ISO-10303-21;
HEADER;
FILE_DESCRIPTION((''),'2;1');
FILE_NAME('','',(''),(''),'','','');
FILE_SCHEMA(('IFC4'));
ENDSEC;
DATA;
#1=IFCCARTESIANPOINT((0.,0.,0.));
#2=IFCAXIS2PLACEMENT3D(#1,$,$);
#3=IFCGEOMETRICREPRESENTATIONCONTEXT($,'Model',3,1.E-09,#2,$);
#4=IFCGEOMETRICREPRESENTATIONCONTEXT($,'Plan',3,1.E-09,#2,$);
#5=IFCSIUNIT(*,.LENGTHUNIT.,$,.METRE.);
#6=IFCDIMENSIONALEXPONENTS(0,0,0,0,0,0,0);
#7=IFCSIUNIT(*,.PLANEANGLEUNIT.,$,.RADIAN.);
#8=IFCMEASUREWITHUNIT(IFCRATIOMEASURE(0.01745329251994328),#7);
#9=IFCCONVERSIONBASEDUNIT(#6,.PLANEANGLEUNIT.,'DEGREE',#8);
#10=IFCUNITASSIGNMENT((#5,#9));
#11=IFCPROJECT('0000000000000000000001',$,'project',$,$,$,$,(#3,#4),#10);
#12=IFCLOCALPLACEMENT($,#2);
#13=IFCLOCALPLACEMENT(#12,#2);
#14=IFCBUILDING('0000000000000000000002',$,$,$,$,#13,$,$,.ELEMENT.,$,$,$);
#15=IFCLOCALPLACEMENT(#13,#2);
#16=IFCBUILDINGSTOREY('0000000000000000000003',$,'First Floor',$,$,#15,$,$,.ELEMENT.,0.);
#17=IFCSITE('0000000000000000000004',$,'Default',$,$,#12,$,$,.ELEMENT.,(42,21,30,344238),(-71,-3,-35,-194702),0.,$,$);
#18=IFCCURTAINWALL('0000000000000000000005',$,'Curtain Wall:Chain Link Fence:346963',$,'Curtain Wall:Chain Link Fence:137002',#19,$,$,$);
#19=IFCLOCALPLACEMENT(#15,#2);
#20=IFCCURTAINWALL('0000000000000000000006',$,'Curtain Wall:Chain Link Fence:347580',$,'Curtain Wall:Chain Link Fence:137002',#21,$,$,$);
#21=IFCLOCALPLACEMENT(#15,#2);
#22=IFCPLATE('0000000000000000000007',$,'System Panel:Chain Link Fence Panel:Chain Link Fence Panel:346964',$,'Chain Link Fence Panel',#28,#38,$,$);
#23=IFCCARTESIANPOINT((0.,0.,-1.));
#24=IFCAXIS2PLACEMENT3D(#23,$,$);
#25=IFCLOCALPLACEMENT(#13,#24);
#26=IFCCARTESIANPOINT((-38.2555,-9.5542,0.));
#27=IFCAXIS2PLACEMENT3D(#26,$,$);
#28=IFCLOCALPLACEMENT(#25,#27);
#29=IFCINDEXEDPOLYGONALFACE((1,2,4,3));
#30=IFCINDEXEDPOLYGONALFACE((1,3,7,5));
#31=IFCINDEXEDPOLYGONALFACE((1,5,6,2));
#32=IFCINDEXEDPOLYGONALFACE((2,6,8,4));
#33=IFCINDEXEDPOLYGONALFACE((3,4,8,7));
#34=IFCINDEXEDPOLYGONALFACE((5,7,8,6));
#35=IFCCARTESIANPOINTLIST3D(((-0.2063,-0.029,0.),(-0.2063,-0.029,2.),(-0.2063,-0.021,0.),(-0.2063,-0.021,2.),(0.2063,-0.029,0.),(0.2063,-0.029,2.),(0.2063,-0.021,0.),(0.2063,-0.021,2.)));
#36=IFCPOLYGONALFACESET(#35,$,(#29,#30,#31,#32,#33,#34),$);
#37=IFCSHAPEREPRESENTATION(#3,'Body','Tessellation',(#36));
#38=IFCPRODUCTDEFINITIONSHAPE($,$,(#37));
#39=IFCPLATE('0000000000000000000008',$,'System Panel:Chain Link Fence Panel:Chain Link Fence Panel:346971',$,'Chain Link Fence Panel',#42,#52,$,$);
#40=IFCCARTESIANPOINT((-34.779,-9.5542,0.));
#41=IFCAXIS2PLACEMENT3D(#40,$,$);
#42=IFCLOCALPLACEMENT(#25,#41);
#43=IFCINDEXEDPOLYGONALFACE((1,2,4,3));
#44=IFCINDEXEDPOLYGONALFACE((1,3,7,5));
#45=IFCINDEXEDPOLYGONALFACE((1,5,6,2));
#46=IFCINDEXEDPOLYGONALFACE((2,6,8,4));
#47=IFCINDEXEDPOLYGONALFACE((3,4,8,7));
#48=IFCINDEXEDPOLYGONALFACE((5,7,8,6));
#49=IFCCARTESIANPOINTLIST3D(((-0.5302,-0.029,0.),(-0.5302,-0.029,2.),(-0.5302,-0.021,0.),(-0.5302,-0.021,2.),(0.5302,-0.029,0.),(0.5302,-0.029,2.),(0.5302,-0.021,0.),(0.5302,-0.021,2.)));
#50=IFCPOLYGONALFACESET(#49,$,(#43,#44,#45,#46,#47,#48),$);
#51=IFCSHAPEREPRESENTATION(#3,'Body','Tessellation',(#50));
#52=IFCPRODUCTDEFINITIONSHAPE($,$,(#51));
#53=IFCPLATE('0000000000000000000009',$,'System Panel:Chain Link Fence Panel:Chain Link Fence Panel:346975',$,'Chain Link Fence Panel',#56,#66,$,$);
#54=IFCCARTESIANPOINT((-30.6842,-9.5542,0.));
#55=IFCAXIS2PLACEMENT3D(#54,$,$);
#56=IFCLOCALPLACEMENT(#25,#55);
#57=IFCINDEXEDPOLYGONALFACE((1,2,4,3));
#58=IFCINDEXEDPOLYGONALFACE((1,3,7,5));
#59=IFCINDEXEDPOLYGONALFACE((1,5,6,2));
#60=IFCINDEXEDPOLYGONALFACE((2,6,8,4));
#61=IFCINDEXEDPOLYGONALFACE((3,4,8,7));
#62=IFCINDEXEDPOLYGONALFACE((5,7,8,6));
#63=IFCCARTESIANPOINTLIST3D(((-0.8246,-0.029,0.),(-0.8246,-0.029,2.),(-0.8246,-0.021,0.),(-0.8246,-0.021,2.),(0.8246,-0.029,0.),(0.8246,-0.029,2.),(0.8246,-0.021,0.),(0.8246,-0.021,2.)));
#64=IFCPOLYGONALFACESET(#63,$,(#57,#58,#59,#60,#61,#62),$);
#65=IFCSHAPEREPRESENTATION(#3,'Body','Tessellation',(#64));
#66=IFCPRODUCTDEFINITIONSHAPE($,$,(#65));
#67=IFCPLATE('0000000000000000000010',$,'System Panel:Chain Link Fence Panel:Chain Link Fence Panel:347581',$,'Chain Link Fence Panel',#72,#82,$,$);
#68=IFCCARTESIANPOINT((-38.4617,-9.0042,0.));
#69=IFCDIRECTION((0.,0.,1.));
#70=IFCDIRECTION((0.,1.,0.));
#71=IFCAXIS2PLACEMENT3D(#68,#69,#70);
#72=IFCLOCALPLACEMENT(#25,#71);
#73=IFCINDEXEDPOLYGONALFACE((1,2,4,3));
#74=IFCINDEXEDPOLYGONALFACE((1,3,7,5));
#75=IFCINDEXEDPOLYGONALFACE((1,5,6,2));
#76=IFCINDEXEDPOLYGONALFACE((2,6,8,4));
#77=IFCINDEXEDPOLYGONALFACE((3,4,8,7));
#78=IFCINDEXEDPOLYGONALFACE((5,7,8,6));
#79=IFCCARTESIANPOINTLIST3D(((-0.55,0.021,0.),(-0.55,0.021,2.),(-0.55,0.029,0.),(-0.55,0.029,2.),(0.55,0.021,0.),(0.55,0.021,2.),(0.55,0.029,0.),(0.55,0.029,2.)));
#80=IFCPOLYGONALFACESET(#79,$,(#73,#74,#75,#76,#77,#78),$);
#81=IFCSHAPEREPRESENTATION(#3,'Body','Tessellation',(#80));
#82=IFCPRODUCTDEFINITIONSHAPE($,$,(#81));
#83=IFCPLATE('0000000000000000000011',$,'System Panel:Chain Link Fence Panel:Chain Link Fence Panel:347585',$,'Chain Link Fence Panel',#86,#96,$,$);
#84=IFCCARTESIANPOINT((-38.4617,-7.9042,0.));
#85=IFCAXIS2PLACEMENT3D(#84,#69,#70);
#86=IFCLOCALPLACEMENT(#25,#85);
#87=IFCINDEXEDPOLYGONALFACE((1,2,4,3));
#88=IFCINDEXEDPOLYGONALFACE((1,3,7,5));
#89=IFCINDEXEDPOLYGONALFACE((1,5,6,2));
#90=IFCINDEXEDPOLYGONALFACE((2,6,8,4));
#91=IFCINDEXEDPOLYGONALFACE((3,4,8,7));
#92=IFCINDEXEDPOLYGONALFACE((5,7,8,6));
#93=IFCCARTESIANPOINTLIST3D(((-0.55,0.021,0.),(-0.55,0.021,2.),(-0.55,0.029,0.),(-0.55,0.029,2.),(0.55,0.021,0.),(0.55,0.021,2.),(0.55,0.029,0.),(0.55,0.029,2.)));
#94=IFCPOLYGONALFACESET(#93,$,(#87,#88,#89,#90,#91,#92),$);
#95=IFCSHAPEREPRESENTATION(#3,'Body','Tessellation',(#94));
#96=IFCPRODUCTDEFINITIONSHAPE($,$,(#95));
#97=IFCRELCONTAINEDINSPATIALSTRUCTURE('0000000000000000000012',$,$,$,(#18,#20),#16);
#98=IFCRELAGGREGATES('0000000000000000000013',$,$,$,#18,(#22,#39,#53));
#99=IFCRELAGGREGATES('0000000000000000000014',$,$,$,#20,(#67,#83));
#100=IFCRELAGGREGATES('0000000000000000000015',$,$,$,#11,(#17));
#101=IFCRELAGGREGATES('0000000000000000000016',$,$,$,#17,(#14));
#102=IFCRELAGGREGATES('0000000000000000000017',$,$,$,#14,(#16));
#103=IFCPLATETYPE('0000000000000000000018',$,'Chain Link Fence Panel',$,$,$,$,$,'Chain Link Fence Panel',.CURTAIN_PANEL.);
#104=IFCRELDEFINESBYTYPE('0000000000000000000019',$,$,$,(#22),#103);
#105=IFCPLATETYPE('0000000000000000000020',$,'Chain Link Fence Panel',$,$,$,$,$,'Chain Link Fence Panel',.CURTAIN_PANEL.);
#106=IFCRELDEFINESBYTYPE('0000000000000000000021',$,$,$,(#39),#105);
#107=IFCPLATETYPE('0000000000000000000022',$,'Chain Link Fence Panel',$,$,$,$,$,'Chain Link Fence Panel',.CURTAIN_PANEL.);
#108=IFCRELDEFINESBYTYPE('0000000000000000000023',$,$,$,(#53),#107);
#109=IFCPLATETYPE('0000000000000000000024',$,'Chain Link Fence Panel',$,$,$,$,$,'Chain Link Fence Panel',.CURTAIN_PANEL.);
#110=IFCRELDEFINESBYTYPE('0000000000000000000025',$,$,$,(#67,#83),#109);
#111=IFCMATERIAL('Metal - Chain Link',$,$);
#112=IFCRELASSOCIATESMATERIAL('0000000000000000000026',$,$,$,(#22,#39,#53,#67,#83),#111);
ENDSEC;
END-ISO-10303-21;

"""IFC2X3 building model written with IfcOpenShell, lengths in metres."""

from ifc_helpers import new_model, entity, si_unit, converted_unit, frame, origin, origin_2d_with_axis, place, context, project, spatial, rectangle, extrude, source, transform, mapped, material, type_object, type_shapes, element, aggregate, save


model = new_model("IFC2X3")

# Units and contexts
model_context = context("Model", 3, precision=1e-09, world=origin())
plan_context = context("Plan", 3, precision=1e-09, world=origin())
ifc_project = project(units=[si_unit("LENGTHUNIT", "METRE"), converted_unit("PLANEANGLEUNIT", "DEGREE", entity("IfcRatioMeasure", 0.01745329251994328), si_unit("PLANEANGLEUNIT", "RADIAN"), dimensions=[0, 0, 0, 0, 0, 0, 0])], contexts=[model_context, plan_context])

# Site, building, storey
site_placement = place(None, origin())
site = spatial("IfcSite", under=ifc_project, at=site_placement, Name="Default", CompositionType="ELEMENT", RefLatitude=(42, 21, 30, 344238), RefLongitude=(-71, -3, -35, -194702), RefElevation=0.0)
building_placement = place(site_placement, origin())
building = spatial("IfcBuilding", under=site, at=building_placement, CompositionType="ELEMENT")
storey_placement = place(building_placement, origin())
storey = spatial("IfcBuildingStorey", under=building, at=storey_placement, Name="First Floor", CompositionType="ELEMENT", Elevation=0.0)

# Curtain walls
curtain_wall_1_placement = place(storey_placement, origin())
curtain_wall_1 = element("IfcCurtainWall", 1, at=curtain_wall_1_placement, inside=storey, Name="Curtain Wall:Chain Link Fence:346963", ObjectType="Curtain Wall:Chain Link Fence:137002")
placement = place(building_placement, frame((0.0, 0.0, -1.0)))
curtain_wall_2_placement = place(storey_placement, origin())
curtain_wall_2 = element("IfcCurtainWall", 2, at=curtain_wall_2_placement, inside=storey, Name="Curtain Wall:Chain Link Fence:347580", ObjectType="Curtain Wall:Chain Link Fence:137002")

# Plates
ifc_material_1 = material(Name="Metal - Chain Link")
plate_type_1 = type_object("IfcPlateType", Name="Chain Link Fence Panel", ElementType="Chain Link Fence Panel", PredefinedType="CURTAIN_PANEL")
shared_shape_1 = source(origin(), model_context, "Body", "SweptSolid", [
    extrude(rectangle(XDim=0.008, YDim=0.4126, at=origin_2d_with_axis()), frame((0.0, -0.025, 0.0), z_axis=(0.0, 0.0, 1.0), x_axis=(0.0, 1.0, 0.0)), (0.0, 0.0, 1.0), 2.0),
])
type_shapes(plate_type_1, [shared_shape_1])
plate_1_placement = place(placement, frame((-38.2555, -9.5542, 0.0)))
plate_1 = element("IfcPlate", 3, at=plate_1_placement, type_object=plate_type_1, material=ifc_material_1, Name="System Panel:Chain Link Fence Panel:Chain Link Fence Panel:346964", ObjectType="Chain Link Fence Panel", context=model_context, shape_type="MappedRepresentation", body=[
    mapped(shared_shape_1, transform((0.0, 0.0, 0.0), scale=1.0)),
])
plate_type_2 = type_object("IfcPlateType", Name="Chain Link Fence Panel", ElementType="Chain Link Fence Panel", PredefinedType="CURTAIN_PANEL")
shared_shape_2 = source(origin(), model_context, "Body", "SweptSolid", [
    extrude(rectangle(XDim=0.008, YDim=1.0604, at=origin_2d_with_axis()), frame((0.0, -0.025, 0.0), z_axis=(0.0, 0.0, 1.0), x_axis=(0.0, 1.0, 0.0)), (0.0, 0.0, 1.0), 2.0),
])
type_shapes(plate_type_2, [shared_shape_2])
plate_2_placement = place(placement, frame((-34.779, -9.5542, 0.0)))
plate_2 = element("IfcPlate", 4, at=plate_2_placement, type_object=plate_type_2, material=ifc_material_1, Name="System Panel:Chain Link Fence Panel:Chain Link Fence Panel:346971", ObjectType="Chain Link Fence Panel", context=model_context, shape_type="MappedRepresentation", body=[
    mapped(shared_shape_2, transform((0.0, 0.0, 0.0), scale=1.0)),
])
plate_type_3 = type_object("IfcPlateType", Name="Chain Link Fence Panel", ElementType="Chain Link Fence Panel", PredefinedType="CURTAIN_PANEL")
shared_shape_3 = source(origin(), model_context, "Body", "SweptSolid", [
    extrude(rectangle(XDim=0.008, YDim=1.6491, at=origin_2d_with_axis()), frame((0.0, -0.025, 0.0), z_axis=(0.0, 0.0, 1.0), x_axis=(0.0, 1.0, 0.0)), (0.0, 0.0, 1.0), 2.0),
])
type_shapes(plate_type_3, [shared_shape_3])
plate_3_placement = place(placement, frame((-30.6842, -9.5542, 0.0)))
plate_3 = element("IfcPlate", 5, at=plate_3_placement, type_object=plate_type_3, material=ifc_material_1, Name="System Panel:Chain Link Fence Panel:Chain Link Fence Panel:346975", ObjectType="Chain Link Fence Panel", context=model_context, shape_type="MappedRepresentation", body=[
    mapped(shared_shape_3, transform((0.0, 0.0, 0.0), scale=1.0)),
])
aggregate(curtain_wall_1, [plate_1, plate_2, plate_3])
plate_type_4 = type_object("IfcPlateType", Name="Chain Link Fence Panel", ElementType="Chain Link Fence Panel", PredefinedType="CURTAIN_PANEL")
shared_shape_4 = source(origin(), model_context, "Body", "SweptSolid", [
    extrude(rectangle(XDim=0.008, YDim=1.1, at=origin_2d_with_axis()), frame((0.0, 0.025, 0.0), z_axis=(0.0, 0.0, 1.0), x_axis=(0.0, 1.0, 0.0)), (0.0, 0.0, 1.0), 2.0),
])
type_shapes(plate_type_4, [shared_shape_4])
plate_4_placement = place(placement, frame((-38.4617, -9.0042, 0.0), z_axis=(0.0, 0.0, 1.0), x_axis=(0.0, 1.0, 0.0)))
plate_4 = element("IfcPlate", 6, at=plate_4_placement, type_object=plate_type_4, material=ifc_material_1, Name="System Panel:Chain Link Fence Panel:Chain Link Fence Panel:347581", ObjectType="Chain Link Fence Panel", context=model_context, shape_type="MappedRepresentation", body=[
    mapped(shared_shape_4, transform((0.0, 0.0, 0.0), scale=1.0)),
])
plate_5_placement = place(placement, frame((-38.4617, -7.9042, 0.0), z_axis=(0.0, 0.0, 1.0), x_axis=(0.0, 1.0, 0.0)))
plate_5 = element("IfcPlate", 7, at=plate_5_placement, type_object=plate_type_4, material=ifc_material_1, Name="System Panel:Chain Link Fence Panel:Chain Link Fence Panel:347585", ObjectType="Chain Link Fence Panel", context=model_context, shape_type="MappedRepresentation", body=[
    mapped(shared_shape_4, transform((0.0, 0.0, 0.0), scale=1.0)),
])
aggregate(curtain_wall_2, [plate_4, plate_5])

save(model, "model.ifc")
